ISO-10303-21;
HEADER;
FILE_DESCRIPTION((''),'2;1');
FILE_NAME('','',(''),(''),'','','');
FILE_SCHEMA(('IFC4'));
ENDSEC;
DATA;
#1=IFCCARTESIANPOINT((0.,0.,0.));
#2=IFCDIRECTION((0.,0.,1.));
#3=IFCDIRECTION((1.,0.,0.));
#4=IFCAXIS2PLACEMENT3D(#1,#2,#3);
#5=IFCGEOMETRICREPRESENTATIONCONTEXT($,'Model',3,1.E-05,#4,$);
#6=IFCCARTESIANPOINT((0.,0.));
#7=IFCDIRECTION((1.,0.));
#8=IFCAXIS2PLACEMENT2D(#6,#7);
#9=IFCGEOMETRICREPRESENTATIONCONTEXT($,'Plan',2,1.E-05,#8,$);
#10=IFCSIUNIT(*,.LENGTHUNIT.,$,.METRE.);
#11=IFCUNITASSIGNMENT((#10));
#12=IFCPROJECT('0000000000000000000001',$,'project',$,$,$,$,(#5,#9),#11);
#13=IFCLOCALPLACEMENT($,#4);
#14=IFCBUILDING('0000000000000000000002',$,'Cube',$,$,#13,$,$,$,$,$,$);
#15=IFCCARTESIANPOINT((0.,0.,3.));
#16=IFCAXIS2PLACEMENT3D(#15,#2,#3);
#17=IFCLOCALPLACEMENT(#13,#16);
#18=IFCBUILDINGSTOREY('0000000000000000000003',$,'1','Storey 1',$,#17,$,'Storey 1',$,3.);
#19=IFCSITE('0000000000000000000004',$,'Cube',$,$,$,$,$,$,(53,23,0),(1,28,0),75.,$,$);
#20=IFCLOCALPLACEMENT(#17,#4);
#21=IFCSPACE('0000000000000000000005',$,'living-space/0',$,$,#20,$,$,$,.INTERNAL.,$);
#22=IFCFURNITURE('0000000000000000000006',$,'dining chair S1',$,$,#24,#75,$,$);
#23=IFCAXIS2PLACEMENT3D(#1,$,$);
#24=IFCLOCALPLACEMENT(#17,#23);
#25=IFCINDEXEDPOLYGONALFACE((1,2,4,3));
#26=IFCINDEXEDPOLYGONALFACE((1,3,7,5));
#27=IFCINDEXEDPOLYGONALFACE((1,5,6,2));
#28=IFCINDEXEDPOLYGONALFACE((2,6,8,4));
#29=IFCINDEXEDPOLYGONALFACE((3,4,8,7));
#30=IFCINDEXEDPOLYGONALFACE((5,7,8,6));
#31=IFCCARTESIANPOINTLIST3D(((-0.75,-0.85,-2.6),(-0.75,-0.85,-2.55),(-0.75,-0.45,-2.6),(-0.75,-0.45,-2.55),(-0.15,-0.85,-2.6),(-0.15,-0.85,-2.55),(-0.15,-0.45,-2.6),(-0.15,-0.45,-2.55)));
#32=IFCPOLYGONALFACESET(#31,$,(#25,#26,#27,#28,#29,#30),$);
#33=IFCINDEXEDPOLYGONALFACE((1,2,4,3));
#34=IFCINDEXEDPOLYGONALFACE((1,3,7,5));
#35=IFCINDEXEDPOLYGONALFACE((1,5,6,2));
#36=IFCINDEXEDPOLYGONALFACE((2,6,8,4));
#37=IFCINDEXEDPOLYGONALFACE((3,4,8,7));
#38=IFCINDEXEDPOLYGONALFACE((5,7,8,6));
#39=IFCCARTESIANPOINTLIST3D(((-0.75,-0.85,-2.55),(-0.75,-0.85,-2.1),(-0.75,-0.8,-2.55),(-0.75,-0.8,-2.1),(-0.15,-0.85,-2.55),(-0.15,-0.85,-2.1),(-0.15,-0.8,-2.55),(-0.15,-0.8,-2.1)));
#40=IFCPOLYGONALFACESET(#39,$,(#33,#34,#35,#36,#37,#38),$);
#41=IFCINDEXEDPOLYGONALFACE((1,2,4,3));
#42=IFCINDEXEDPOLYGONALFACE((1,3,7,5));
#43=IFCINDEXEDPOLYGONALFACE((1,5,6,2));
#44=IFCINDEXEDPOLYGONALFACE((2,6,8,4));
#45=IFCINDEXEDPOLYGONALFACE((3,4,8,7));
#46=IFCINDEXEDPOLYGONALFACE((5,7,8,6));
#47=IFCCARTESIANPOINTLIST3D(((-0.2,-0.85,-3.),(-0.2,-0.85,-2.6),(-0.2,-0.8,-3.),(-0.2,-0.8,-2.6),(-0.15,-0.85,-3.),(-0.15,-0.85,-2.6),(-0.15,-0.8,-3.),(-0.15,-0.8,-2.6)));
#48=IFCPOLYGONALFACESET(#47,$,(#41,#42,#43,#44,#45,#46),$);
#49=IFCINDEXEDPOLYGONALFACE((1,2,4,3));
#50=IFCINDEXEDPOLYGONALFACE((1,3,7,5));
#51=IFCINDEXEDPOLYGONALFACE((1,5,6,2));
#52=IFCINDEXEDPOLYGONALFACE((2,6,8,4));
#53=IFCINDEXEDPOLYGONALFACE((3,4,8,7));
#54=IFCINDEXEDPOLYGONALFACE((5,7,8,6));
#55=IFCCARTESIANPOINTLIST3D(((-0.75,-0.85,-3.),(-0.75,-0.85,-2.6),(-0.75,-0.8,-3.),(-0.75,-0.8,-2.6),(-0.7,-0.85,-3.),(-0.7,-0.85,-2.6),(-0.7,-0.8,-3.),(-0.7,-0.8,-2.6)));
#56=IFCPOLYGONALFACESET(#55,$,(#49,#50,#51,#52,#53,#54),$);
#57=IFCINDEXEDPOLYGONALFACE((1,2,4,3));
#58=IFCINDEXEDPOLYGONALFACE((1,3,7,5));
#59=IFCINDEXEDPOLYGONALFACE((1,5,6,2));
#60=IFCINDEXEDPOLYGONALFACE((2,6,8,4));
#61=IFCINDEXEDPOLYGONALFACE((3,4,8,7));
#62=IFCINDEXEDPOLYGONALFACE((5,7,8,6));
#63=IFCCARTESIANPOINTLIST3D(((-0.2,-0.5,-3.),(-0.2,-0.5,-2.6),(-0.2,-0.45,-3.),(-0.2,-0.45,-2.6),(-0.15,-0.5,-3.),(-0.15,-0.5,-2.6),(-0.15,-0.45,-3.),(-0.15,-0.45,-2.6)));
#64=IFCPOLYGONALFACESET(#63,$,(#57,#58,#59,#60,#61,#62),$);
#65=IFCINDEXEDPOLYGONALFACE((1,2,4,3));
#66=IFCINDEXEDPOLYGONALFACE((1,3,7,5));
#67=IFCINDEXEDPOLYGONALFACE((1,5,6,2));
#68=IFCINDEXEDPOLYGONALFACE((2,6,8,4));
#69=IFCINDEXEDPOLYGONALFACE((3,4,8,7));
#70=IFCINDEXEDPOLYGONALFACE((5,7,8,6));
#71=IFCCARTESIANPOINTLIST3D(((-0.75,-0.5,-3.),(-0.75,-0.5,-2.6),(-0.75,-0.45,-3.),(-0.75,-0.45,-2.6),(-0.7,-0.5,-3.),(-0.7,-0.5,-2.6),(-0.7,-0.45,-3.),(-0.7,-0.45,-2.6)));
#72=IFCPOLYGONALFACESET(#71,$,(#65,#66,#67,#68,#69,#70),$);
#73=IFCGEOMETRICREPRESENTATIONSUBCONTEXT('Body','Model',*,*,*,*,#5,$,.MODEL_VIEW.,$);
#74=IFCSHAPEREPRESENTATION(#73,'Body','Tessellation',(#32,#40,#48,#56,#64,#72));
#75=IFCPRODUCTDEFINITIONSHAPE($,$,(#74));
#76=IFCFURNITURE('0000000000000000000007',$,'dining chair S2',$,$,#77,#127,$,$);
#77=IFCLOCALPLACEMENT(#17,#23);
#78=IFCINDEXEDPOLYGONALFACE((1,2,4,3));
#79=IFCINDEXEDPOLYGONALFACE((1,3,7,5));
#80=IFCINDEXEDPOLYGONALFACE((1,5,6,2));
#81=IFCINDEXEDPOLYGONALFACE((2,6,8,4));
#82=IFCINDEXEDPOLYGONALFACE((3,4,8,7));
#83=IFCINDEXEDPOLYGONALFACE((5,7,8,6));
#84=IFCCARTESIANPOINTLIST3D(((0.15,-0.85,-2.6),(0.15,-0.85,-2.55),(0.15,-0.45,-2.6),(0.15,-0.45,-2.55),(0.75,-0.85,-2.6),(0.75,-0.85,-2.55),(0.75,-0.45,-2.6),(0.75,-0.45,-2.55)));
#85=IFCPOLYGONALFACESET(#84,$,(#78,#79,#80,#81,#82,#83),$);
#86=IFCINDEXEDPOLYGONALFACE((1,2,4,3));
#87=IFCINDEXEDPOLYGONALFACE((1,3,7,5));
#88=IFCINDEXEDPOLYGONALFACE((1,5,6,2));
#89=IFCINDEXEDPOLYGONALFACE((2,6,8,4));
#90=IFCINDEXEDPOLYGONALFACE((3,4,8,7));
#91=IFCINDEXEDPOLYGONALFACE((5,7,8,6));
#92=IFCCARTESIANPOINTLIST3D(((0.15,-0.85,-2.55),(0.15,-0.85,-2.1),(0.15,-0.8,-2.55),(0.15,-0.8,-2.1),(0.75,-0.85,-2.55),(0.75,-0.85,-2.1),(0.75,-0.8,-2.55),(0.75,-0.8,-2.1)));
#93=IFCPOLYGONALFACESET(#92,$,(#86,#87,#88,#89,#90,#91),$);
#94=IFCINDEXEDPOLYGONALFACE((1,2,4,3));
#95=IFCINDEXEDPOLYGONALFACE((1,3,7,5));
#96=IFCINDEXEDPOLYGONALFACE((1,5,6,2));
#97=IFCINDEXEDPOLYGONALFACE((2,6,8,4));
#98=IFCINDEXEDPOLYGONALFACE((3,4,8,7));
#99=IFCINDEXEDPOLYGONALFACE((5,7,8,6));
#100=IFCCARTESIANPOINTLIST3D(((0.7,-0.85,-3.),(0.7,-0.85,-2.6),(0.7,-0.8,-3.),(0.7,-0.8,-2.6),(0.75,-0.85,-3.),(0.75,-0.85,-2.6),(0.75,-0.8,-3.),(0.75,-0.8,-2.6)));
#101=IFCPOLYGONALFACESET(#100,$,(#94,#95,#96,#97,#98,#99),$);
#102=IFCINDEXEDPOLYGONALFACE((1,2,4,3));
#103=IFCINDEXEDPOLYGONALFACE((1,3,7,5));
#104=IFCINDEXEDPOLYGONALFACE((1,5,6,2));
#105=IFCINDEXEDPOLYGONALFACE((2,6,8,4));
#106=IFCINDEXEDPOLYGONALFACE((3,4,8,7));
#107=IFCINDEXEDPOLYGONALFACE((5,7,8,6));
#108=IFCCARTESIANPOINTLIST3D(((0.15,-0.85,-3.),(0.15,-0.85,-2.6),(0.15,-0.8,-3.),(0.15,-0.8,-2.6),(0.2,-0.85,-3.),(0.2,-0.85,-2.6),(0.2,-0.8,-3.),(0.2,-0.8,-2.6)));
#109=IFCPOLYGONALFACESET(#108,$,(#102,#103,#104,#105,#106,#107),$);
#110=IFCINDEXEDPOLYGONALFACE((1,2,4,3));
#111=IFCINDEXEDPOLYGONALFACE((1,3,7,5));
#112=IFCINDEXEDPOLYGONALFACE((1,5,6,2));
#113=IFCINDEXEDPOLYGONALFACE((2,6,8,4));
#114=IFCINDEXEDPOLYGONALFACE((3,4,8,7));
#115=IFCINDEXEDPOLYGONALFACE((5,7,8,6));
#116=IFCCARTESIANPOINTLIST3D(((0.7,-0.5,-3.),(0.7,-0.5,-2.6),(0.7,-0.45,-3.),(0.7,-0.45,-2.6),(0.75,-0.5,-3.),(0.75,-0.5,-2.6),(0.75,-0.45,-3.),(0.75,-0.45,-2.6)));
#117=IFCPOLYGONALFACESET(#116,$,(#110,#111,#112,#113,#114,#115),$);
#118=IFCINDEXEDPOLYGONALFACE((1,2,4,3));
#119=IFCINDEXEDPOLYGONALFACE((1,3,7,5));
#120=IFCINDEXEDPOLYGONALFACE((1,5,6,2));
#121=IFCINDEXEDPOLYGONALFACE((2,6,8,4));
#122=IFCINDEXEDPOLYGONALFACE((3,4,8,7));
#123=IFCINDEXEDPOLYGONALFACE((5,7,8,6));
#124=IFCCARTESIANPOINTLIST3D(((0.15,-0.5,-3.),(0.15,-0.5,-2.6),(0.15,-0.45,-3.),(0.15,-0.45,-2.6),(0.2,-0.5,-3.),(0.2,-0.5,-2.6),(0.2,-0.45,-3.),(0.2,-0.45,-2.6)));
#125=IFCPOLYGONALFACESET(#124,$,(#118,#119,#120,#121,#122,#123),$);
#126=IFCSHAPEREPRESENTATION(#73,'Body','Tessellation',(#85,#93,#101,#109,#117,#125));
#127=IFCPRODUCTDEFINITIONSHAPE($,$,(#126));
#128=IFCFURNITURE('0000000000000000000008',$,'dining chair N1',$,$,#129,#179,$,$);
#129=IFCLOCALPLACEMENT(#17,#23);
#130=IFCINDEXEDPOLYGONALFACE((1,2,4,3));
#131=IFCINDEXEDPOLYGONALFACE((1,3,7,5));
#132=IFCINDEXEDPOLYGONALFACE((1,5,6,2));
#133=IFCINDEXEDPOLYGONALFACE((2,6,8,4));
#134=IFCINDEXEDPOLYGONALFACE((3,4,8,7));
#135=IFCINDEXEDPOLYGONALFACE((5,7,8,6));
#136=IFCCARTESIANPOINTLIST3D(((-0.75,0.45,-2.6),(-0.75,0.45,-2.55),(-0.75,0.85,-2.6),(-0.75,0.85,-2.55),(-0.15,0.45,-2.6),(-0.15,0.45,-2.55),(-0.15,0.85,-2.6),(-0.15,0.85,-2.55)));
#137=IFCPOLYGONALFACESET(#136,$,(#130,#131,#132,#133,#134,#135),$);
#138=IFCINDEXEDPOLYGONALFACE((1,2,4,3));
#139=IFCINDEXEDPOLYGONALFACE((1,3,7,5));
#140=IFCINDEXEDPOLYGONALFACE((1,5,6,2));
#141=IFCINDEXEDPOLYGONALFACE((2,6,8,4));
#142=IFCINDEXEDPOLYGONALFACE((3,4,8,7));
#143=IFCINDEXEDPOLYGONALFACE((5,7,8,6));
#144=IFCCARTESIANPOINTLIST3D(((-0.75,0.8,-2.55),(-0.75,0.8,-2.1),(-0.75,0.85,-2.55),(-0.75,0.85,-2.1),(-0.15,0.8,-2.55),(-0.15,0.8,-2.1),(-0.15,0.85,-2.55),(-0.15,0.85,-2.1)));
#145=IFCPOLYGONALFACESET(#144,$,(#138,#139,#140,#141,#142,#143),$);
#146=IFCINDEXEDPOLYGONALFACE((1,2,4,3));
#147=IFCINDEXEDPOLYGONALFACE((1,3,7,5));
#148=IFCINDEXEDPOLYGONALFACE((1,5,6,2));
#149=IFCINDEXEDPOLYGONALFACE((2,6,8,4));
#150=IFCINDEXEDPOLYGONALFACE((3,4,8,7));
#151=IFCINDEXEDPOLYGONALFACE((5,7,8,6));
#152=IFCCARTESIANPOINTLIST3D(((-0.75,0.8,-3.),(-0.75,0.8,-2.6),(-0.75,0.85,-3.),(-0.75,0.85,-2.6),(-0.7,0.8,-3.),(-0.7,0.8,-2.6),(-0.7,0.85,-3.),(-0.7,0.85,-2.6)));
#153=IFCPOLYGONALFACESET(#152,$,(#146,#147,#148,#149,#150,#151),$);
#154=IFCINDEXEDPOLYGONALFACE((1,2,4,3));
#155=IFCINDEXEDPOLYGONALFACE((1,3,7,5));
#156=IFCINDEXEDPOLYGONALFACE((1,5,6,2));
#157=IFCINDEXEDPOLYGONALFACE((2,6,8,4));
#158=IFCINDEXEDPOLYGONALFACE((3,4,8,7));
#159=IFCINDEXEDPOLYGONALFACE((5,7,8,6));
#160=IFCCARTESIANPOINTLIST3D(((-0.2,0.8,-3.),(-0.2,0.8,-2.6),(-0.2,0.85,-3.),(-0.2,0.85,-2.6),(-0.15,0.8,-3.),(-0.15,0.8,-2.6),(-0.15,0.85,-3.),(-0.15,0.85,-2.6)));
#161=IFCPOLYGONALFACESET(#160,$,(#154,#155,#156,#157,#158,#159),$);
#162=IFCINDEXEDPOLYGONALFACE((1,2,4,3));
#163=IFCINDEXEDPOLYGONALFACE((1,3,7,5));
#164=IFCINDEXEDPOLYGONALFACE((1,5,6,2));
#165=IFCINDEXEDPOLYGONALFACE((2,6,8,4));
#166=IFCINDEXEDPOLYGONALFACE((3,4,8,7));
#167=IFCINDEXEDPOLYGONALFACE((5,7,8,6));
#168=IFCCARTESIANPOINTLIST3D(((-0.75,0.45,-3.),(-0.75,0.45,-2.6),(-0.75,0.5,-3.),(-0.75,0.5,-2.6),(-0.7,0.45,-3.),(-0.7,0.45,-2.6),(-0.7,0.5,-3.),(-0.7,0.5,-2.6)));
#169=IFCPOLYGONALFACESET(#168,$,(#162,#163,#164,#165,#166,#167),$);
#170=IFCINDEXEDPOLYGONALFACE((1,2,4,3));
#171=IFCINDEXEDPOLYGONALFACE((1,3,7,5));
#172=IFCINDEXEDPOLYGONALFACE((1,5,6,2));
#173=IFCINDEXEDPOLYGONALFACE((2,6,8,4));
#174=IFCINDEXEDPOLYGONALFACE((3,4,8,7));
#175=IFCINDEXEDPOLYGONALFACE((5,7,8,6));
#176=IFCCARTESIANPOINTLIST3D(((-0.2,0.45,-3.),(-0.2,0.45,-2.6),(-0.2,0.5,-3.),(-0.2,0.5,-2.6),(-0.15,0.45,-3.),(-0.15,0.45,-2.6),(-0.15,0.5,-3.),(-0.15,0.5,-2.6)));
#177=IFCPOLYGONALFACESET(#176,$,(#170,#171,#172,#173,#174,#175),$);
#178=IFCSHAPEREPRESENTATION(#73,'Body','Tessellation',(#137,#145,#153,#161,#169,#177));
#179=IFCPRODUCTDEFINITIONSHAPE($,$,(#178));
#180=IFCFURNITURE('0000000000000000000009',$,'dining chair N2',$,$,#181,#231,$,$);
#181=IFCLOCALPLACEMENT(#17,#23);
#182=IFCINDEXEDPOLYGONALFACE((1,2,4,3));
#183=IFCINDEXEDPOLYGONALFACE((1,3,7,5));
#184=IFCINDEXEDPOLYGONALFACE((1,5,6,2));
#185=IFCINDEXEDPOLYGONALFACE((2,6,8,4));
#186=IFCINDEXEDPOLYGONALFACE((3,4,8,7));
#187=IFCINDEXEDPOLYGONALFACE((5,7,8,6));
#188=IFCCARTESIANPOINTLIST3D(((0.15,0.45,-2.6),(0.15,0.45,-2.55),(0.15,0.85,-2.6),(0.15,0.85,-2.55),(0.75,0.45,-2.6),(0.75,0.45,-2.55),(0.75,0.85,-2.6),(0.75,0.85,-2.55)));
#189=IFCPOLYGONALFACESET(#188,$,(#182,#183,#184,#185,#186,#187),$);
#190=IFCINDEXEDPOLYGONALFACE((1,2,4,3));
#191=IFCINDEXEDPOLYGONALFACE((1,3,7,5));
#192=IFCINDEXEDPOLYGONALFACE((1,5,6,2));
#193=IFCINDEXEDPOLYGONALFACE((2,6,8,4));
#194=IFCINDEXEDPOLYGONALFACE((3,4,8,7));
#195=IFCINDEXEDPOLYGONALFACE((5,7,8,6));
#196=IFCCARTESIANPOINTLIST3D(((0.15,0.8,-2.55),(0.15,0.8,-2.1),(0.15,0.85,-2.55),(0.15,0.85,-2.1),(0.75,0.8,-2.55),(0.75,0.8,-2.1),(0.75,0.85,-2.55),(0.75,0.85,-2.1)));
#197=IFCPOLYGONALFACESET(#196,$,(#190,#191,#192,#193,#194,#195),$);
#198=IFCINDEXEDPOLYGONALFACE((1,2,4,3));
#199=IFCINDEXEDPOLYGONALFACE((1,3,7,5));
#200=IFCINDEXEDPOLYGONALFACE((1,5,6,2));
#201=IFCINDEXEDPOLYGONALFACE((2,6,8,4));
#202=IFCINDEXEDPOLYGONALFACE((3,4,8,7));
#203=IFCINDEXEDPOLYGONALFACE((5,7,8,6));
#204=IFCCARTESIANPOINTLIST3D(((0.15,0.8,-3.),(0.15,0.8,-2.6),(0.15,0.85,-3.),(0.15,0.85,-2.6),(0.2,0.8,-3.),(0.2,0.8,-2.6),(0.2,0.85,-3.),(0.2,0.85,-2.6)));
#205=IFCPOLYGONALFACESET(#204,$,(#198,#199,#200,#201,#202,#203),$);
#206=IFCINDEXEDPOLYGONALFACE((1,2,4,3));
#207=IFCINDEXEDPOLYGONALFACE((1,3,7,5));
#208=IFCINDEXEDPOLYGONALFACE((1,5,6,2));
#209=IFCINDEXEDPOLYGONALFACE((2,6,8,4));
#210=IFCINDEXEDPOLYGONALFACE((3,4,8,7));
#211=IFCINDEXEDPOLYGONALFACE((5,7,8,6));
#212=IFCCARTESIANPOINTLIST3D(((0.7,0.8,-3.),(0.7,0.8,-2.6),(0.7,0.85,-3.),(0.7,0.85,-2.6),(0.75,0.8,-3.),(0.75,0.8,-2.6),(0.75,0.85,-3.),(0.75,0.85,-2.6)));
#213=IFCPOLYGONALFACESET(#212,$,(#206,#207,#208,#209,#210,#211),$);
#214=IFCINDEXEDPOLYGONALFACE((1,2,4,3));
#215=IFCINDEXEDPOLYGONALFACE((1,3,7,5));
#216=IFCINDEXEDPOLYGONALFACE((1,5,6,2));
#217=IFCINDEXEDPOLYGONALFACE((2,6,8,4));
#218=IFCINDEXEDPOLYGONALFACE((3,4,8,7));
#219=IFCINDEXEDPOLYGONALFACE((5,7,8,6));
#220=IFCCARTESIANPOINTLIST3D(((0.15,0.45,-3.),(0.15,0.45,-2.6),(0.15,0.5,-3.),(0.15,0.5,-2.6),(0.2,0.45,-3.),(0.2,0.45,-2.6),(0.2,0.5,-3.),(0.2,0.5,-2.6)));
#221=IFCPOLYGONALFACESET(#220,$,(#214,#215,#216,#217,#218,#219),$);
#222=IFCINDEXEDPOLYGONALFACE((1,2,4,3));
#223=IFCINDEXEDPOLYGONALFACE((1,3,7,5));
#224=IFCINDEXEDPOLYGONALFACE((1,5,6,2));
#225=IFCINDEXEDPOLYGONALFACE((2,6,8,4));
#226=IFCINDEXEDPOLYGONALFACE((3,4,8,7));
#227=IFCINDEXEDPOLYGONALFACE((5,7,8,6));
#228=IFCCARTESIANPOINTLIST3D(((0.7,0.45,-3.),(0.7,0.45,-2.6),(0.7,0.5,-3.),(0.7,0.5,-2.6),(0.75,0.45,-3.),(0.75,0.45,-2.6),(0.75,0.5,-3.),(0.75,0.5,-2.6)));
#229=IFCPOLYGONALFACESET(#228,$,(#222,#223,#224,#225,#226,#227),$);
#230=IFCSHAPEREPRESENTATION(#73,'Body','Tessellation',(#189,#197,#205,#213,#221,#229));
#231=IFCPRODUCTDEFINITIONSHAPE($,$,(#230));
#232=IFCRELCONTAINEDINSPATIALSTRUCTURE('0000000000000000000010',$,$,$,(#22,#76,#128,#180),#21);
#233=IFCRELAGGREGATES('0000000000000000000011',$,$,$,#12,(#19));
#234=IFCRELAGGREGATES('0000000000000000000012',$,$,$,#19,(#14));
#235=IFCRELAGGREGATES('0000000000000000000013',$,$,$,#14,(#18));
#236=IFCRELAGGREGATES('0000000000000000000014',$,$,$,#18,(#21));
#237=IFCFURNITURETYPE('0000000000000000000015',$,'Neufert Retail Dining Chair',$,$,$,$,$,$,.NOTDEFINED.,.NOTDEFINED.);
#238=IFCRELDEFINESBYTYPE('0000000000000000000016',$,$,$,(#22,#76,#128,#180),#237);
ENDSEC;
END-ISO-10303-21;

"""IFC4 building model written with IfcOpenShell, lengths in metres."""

from ifc_helpers import new_model, entity, si_unit, frame, origin_with_axes, origin_2d_with_axis, place, context, subcontext, project, spatial, line, indexed_curve, outline, extrude, shape, source, transform, mapped, type_object, type_shapes, element, save


model = new_model("IFC4")

# Units and contexts
model_context = context("Model", 3, precision=1e-05, world=origin_with_axes())
plan_context = context("Plan", 2, precision=1e-05, world=origin_2d_with_axis())
body_context_1 = subcontext(model_context, "Body", "Model", "MODEL_VIEW")
body_context_2 = subcontext(plan_context, "Body", "Plan", "PLAN_VIEW")
ifc_project = project(units=[si_unit("LENGTHUNIT", "METRE")], contexts=[model_context, plan_context])

# Site, building, storey
site = spatial("IfcSite", under=ifc_project, Name="Cube", RefLatitude=(53, 23, 0), RefLongitude=(1, 28, 0), RefElevation=75.0)
building_placement = place(None, origin_with_axes())
building = spatial("IfcBuilding", under=site, at=building_placement, Name="Cube")
storey_placement = place(building_placement, frame((0.0, 0.0, 3.0), z_axis=(0.0, 0.0, 1.0), x_axis=(1.0, 0.0, 0.0)))
storey = spatial("IfcBuildingStorey", under=building, at=storey_placement, Name="1", Description="Storey 1", LongName="Storey 1", Elevation=3.0)

# Shared definitions
space_placement = place(storey_placement, origin_with_axes())
space = spatial("IfcSpace", under=storey, at=space_placement, Name="living-space/0", PredefinedType="INTERNAL")

# Furniture
furniture_type_1 = type_object("IfcFurnitureType", Name="Neufert Retail Dining Chair", AssemblyPlace="NOTDEFINED", PredefinedType="NOTDEFINED")
shared_shape_1 = source(origin_with_axes(), body_context_1, "Body", "SweptSolid", [
    extrude(outline(indexed_curve([(-0.3, 0.0), (0.3, 0.0), (0.3, -0.4), (-0.3, -0.4)], segments=[line(1, 2, 3, 4, 1)])), frame((0.0, 0.0, 0.45), z_axis=(0.0, 0.0, 1.0), x_axis=(1.0, 0.0, 0.0)), (0.0, 0.0, -1.0), 0.05),
    extrude(outline(indexed_curve([(-0.3, 0.0), (0.3, 0.0), (0.3, -0.05), (-0.3, -0.05)], segments=[line(1, 2, 3, 4, 1)])), frame((0.0, 0.0, 0.9), z_axis=(0.0, 0.0, 1.0), x_axis=(1.0, 0.0, 0.0)), (0.0, 0.0, -1.0), 0.45),
    extrude(outline(indexed_curve([(-0.3, 0.0), (-0.25, 0.0), (-0.25, -0.05), (-0.3, -0.05)], segments=[line(1, 2, 3, 4, 1)])), origin_with_axes(), (0.0, 0.0, 1.0), 0.4),
    extrude(outline(indexed_curve([(0.3, 0.0), (0.25, 0.0), (0.25, -0.05), (0.3, -0.05)], segments=[line(1, 2, 3, 4, 1)])), origin_with_axes(), (0.0, 0.0, 1.0), 0.4),
    extrude(outline(indexed_curve([(-0.3, -0.4), (-0.25, -0.4), (-0.25, -0.35), (-0.3, -0.35)], segments=[line(1, 2, 3, 4, 1)])), origin_with_axes(), (0.0, 0.0, 1.0), 0.4),
    extrude(outline(indexed_curve([(0.3, -0.4), (0.25, -0.4), (0.25, -0.35), (0.3, -0.35)], segments=[line(1, 2, 3, 4, 1)])), origin_with_axes(), (0.0, 0.0, 1.0), 0.4),
])
shared_shape_2 = source(origin_with_axes(), body_context_2, "Body", "Curve2D", [
    entity("IfcIndexedPolyCurve", entity("IfcCartesianPointList2D", [[-0.3, -0.4], [0.3, -0.4]])),
    entity("IfcIndexedPolyCurve", entity("IfcCartesianPointList2D", [[-0.3, -0.4], [-0.3, -0.3], [-0.2121, -0.0879], [0.0, 0.0], [0.2121, -0.0879], [0.3, -0.3], [0.3, -0.4]]), [entity("IfcLineIndex", [1, 2]), entity("IfcArcIndex", [2, 3, 4]), entity("IfcArcIndex", [4, 5, 6]), entity("IfcLineIndex", [6, 7])]),
    entity("IfcIndexedPolyCurve", entity("IfcCartesianPointList2D", [[-0.26, -0.4], [-0.26, -0.3], [-0.1838, -0.1162], [0.0, -0.04], [0.1838, -0.1162], [0.26, -0.3], [0.26, -0.4]]), [entity("IfcLineIndex", [1, 2]), entity("IfcArcIndex", [2, 3, 4]), entity("IfcArcIndex", [4, 5, 6]), entity("IfcLineIndex", [6, 7])]),
])
type_shapes(furniture_type_1, [shared_shape_1, shared_shape_2])
for number, where, z_axis, x_axis, name in (
    (1, (-0.45, -0.85, -3.0), (0.0, 0.0, 1.0), (-1.0, 0.0, 0.0), "dining chair S1"),
    (2, (0.45, -0.85, -3.0), (0.0, 0.0, 1.0), (-1.0, 0.0, 0.0), "dining chair S2"),
    (3, (-0.45, 0.85, -3.0), (0.0, 0.0, 1.0), (1.0, 0.0, 0.0), "dining chair N1"),
    (4, (0.45, 0.85, -3.0), (0.0, 0.0, 1.0), (1.0, 0.0, 0.0), "dining chair N2"),
):
    element("IfcFurniture", number, at=place(space_placement, frame(where, z_axis=z_axis, x_axis=x_axis)), inside=space, type_object=furniture_type_1, Name=name, shapes=[
        shape(body_context_1, "Body", "MappedRepresentation", [mapped(shared_shape_1, transform((0.0, 0.0, 0.0), x_axis=(1.0, 0.0, 0.0), y_axis=(0.0, 1.0, 0.0), z_axis=(0.0, 0.0, 1.0), scale=1.0))]),
        shape(body_context_2, "Body", "MappedRepresentation", [mapped(shared_shape_2, transform((0.0, 0.0, 0.0), x_axis=(1.0, 0.0, 0.0), y_axis=(0.0, 1.0, 0.0), z_axis=(0.0, 0.0, 1.0), scale=1.0))]),
    ])

save(model, "model.ifc")
